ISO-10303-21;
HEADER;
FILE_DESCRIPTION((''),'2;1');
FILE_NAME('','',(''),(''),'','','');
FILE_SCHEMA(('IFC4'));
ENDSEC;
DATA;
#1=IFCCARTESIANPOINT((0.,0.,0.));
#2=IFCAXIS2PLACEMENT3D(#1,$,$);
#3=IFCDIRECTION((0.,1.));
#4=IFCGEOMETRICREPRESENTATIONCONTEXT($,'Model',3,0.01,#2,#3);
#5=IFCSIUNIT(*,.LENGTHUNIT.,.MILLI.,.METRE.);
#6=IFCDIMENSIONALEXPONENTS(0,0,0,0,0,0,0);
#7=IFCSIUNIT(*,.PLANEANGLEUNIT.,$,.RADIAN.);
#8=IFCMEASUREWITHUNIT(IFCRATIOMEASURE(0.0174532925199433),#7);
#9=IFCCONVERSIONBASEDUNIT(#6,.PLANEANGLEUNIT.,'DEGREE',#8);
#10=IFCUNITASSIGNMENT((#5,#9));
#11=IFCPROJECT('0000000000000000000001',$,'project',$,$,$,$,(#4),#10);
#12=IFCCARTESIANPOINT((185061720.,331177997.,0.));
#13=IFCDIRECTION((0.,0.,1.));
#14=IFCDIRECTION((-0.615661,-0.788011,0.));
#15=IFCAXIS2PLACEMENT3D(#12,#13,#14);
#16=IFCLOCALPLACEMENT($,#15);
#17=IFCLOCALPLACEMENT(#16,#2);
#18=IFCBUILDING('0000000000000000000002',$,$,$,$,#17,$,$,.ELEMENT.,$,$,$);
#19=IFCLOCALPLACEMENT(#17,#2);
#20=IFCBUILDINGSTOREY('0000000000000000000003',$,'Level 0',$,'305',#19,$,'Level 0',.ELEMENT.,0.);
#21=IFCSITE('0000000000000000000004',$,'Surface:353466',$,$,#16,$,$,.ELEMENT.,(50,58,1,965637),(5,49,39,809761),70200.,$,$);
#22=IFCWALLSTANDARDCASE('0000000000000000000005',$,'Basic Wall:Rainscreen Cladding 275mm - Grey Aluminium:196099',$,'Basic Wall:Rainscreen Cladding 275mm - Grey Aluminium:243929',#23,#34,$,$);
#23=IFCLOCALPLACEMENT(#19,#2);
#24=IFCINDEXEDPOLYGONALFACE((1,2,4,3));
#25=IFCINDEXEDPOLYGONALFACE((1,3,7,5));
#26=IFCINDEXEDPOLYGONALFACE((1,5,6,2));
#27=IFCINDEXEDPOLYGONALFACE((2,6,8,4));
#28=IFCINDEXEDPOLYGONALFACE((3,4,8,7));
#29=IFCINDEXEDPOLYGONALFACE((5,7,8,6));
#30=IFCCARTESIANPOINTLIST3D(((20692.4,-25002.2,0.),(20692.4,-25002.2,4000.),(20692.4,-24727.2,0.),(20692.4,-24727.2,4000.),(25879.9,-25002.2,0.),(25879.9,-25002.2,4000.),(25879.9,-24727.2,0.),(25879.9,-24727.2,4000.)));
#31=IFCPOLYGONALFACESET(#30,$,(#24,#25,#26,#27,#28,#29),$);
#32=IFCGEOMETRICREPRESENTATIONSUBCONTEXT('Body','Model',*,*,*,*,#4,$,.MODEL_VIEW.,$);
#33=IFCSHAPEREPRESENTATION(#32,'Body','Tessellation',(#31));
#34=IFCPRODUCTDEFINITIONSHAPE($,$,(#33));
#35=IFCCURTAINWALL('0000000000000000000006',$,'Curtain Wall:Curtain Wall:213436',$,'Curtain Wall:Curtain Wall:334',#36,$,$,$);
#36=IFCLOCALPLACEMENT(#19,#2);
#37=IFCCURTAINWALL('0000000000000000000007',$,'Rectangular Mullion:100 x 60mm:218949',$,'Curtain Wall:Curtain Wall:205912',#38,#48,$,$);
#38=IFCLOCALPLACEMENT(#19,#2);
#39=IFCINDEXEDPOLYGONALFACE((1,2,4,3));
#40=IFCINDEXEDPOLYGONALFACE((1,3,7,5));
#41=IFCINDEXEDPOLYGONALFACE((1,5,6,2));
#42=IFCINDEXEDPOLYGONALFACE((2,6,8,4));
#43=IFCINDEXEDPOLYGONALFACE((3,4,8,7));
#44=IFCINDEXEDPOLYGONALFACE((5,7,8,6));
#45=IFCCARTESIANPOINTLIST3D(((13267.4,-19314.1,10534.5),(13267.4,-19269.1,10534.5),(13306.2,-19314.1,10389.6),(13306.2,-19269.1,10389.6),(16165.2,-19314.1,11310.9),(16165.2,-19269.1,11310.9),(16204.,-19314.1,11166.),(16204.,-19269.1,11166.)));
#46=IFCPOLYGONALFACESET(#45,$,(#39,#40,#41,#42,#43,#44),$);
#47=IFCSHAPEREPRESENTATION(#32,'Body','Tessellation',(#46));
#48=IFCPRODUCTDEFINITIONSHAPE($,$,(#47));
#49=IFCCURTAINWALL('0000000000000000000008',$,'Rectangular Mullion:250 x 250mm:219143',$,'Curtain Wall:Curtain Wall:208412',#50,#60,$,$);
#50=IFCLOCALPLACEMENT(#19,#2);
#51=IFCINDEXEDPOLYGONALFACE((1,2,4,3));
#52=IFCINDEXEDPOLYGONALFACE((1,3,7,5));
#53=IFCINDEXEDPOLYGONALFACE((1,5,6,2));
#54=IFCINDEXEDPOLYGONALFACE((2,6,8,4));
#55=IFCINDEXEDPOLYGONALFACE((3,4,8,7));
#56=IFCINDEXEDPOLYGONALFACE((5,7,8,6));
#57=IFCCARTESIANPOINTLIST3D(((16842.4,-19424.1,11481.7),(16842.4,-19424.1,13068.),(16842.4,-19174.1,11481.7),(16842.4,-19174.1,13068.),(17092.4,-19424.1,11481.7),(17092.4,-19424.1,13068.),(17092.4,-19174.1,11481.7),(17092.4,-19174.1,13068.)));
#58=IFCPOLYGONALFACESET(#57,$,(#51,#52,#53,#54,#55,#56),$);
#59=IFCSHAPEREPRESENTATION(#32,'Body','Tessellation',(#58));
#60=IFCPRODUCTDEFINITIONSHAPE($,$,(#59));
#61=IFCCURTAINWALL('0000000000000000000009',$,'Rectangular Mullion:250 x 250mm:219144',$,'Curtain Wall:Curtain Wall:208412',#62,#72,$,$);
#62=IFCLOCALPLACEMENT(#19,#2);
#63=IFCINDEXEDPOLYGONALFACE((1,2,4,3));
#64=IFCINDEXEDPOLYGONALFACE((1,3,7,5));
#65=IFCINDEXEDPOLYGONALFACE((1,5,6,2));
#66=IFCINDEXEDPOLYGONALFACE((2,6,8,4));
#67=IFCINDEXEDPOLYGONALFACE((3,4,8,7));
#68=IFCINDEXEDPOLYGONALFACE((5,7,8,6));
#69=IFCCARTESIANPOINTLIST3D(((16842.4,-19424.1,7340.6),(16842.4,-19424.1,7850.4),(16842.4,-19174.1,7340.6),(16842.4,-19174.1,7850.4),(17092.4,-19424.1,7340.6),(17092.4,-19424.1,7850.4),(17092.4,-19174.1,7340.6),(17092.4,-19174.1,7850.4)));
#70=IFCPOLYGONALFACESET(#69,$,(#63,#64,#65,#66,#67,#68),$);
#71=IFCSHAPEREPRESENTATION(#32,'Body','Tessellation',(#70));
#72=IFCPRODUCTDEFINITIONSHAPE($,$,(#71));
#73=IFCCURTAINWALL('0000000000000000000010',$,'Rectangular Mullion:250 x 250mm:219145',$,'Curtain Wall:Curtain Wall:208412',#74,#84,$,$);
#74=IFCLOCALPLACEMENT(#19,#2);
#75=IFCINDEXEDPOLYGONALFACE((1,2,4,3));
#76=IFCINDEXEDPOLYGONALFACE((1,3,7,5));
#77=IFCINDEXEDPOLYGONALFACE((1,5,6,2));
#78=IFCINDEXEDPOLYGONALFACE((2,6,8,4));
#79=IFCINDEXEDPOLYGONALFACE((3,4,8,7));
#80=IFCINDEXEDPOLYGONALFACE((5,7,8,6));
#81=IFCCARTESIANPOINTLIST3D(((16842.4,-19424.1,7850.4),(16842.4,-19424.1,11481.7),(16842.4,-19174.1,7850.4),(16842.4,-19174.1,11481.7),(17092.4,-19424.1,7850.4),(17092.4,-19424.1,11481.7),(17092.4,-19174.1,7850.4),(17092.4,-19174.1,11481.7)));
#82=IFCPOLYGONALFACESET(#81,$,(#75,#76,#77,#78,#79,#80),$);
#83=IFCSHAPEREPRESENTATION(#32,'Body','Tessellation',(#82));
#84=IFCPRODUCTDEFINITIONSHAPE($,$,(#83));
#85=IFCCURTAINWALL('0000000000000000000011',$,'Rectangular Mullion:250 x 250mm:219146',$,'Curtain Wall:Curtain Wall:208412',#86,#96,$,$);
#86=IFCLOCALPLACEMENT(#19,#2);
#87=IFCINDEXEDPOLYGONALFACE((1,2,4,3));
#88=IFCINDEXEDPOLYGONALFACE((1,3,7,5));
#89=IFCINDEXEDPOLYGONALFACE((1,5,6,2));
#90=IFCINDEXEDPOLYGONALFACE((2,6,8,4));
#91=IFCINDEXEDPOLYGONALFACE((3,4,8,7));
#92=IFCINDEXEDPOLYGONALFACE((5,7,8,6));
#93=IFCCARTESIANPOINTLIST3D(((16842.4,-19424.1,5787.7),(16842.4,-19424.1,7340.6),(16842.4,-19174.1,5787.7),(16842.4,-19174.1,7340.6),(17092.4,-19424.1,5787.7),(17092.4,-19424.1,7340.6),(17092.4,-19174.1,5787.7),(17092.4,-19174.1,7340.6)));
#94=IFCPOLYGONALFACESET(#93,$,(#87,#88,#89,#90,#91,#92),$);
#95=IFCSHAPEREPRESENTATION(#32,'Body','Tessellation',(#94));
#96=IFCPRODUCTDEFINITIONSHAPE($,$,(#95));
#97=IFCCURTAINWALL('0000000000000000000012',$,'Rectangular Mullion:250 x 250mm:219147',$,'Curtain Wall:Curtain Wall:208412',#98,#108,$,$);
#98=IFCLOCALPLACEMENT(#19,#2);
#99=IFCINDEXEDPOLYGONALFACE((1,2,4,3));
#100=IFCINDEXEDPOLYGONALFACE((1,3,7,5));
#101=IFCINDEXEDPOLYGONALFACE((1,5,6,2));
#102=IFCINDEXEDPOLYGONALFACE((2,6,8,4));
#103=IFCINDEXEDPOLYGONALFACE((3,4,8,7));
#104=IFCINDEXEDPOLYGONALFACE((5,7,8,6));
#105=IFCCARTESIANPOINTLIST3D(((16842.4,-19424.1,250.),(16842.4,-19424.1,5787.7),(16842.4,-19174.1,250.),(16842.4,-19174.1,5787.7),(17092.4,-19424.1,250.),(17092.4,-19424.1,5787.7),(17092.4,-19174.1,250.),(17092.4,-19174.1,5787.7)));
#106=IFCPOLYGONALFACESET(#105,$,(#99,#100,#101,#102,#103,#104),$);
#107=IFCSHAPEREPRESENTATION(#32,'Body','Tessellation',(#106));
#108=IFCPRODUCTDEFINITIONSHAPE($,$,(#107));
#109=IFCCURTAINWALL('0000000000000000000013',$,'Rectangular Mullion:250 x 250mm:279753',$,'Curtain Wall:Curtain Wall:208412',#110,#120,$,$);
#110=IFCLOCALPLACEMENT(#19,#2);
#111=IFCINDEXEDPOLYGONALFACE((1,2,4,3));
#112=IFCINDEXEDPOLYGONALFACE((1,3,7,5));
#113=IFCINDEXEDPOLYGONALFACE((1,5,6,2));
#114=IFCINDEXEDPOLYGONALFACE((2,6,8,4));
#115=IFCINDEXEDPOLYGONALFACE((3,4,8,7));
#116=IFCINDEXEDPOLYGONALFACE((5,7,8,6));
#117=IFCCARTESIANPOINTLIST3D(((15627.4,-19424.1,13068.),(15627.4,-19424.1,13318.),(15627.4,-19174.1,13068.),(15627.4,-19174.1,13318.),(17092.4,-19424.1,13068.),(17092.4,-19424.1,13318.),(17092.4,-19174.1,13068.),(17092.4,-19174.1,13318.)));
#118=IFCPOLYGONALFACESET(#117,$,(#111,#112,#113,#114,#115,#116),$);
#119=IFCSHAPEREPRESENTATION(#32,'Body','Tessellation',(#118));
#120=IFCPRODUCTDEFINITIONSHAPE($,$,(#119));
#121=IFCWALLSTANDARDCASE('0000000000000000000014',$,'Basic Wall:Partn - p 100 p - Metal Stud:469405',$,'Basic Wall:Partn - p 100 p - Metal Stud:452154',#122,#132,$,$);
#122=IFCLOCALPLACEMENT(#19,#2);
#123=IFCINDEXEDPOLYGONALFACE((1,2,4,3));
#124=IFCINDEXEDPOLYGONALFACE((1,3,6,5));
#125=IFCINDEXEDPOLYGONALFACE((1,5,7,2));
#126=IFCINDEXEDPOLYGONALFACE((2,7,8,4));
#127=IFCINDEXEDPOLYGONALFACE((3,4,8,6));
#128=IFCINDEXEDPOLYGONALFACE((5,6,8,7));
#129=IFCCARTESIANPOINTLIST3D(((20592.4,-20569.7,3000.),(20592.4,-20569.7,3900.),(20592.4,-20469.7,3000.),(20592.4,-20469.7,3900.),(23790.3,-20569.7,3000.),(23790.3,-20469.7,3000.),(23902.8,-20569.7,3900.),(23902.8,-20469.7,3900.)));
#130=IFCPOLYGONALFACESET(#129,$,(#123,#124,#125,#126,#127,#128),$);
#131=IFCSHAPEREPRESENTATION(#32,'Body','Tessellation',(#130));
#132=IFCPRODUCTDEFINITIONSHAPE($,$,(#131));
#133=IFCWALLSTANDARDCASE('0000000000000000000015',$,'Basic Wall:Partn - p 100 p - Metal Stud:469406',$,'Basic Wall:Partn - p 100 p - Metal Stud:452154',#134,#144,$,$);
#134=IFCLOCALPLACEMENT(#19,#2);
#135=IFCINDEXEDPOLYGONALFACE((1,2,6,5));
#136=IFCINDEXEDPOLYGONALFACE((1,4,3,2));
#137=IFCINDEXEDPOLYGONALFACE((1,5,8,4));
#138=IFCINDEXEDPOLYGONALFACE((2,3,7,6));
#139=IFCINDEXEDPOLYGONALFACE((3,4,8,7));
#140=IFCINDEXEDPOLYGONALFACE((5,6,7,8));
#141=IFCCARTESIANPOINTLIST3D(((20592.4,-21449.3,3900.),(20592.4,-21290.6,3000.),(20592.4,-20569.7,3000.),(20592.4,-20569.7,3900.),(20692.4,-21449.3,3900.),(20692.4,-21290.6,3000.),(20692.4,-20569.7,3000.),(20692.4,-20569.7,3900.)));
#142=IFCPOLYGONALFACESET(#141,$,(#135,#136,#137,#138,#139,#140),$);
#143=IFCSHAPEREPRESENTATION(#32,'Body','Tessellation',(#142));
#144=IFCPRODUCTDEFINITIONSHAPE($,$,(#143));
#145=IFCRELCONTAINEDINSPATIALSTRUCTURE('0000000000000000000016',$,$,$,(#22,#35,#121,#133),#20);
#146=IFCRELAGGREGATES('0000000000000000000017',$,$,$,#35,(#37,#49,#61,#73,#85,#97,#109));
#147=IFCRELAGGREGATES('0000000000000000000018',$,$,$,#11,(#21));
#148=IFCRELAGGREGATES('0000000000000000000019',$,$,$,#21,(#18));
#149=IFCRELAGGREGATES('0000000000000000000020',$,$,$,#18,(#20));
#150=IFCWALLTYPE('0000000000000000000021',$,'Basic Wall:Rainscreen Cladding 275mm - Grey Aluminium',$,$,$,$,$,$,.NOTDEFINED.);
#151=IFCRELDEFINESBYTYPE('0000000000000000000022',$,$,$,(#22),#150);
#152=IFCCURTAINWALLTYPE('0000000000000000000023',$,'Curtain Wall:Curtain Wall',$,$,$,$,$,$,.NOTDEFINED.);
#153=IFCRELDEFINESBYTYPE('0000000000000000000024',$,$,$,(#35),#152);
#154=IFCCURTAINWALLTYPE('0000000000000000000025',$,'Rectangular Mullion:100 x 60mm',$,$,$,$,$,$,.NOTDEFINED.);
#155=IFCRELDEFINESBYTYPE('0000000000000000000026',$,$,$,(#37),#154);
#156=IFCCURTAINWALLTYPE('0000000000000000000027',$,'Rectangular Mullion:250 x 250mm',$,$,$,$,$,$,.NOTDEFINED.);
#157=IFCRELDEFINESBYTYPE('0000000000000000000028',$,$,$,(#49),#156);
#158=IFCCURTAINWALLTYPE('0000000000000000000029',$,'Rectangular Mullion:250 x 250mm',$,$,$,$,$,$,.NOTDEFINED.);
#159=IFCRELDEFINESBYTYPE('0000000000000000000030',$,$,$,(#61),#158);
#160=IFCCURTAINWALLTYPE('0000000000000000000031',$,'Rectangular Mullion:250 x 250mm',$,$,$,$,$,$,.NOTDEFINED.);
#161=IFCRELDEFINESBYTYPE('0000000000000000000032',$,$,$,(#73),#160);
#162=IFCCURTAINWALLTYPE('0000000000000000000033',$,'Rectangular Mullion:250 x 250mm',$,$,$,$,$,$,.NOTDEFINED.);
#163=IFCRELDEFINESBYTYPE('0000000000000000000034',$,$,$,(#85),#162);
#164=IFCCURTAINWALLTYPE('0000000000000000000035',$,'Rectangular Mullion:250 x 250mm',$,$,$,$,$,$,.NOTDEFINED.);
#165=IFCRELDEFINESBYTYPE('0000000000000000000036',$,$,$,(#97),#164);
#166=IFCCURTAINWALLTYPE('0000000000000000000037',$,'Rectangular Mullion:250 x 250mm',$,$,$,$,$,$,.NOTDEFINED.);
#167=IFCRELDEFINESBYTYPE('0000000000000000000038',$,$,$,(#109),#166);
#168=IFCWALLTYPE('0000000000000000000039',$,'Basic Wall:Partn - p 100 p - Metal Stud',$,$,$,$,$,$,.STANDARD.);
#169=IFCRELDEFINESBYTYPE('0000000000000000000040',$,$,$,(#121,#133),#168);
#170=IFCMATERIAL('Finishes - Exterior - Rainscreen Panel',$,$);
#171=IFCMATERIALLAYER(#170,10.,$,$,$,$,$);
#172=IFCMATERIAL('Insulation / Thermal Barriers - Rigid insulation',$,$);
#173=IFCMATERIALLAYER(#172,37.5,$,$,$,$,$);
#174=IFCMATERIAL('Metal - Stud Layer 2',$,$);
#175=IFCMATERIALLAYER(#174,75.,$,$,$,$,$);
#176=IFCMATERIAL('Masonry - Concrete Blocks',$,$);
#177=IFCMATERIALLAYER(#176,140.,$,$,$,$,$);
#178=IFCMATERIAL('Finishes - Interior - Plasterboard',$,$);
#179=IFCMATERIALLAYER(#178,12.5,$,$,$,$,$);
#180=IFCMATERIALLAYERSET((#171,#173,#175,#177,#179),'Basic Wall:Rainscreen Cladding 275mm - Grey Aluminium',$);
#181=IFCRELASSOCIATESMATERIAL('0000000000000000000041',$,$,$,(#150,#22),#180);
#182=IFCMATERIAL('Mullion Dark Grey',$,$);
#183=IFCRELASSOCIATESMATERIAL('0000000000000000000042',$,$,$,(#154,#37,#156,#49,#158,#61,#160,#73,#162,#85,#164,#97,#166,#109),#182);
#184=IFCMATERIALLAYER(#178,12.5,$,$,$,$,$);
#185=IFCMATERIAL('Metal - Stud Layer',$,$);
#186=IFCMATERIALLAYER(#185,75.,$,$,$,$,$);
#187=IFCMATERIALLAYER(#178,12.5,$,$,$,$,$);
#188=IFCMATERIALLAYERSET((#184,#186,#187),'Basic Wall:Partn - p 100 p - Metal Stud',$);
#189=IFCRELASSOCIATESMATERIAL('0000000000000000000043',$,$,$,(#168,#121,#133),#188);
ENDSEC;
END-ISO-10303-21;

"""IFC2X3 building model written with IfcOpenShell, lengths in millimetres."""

from ifc_helpers import new_model, entity, si_unit, converted_unit, direction, frame, frame_2d, origin, origin_2d_with_axis, place, context, subcontext, project, spatial, rectangle, extrude, clip, halfspace, source, transform, mapped, material, layer, layer_set, layer_usage, type_object, type_shapes, element, aggregate, save


model = new_model("IFC2X3")

# Units and contexts
model_context = context("Model", 3, precision=0.01, world=origin(), true_north=direction((0.0, 1.0)))
body_context = subcontext(model_context, "Body", "Model", "MODEL_VIEW")
ifc_project = project(units=[si_unit("LENGTHUNIT", "METRE", prefix="MILLI"), converted_unit("PLANEANGLEUNIT", "DEGREE", entity("IfcRatioMeasure", 0.0174532925199433), si_unit("PLANEANGLEUNIT", "RADIAN"), dimensions=[0, 0, 0, 0, 0, 0, 0])], contexts=[model_context])

# Site, building, storey
site_placement = place(None, frame((185061720.0, 331177997.0, 0.0), z_axis=(0.0, 0.0, 1.0), x_axis=(-0.615661, -0.788011, 0.0)))
site = spatial("IfcSite", under=ifc_project, at=site_placement, Name="Surface:353466", CompositionType="ELEMENT", RefLatitude=(50, 58, 1, 965637), RefLongitude=(5, 49, 39, 809761), RefElevation=70200.0)
building_placement = place(site_placement, origin())
building = spatial("IfcBuilding", under=site, at=building_placement, CompositionType="ELEMENT")
storey_placement = place(building_placement, origin())
storey = spatial("IfcBuildingStorey", under=building, at=storey_placement, Name="Level 0", ObjectType="305", LongName="Level 0", CompositionType="ELEMENT", Elevation=0.0)

# Wall
ifc_material_1 = material(Name="Finishes - Exterior - Rainscreen Panel")
ifc_layer_1 = layer(ifc_material_1, 10.0)
ifc_material_2 = material(Name="Insulation / Thermal Barriers - Rigid insulation")
ifc_layer_2 = layer(ifc_material_2, 37.5)
ifc_material_3 = material(Name="Metal - Stud Layer 2")
ifc_layer_3 = layer(ifc_material_3, 75.0)
ifc_material_4 = material(Name="Masonry - Concrete Blocks")
ifc_layer_4 = layer(ifc_material_4, 140.0)
ifc_material_5 = material(Name="Finishes - Interior - Plasterboard")
ifc_layer_5 = layer(ifc_material_5, 12.5)
ifc_layer_set_1 = layer_set([ifc_layer_1, ifc_layer_2, ifc_layer_3, ifc_layer_4, ifc_layer_5], Name="Basic Wall:Rainscreen Cladding 275mm - Grey Aluminium")
ifc_layer_usage_1 = layer_usage(ifc_layer_set_1, "AXIS2", "POSITIVE", -137.5)
wall_type_1 = type_object("IfcWallType", Name="Basic Wall:Rainscreen Cladding 275mm - Grey Aluminium", PredefinedType="NOTDEFINED", material=ifc_layer_set_1)
wall_1_placement = place(storey_placement, frame((20692.4, -24864.7, 0.0)))
element("IfcWallStandardCase", 1, at=wall_1_placement, inside=storey, type_object=wall_type_1, material=ifc_layer_usage_1, Name="Basic Wall:Rainscreen Cladding 275mm - Grey Aluminium:196099", ObjectType="Basic Wall:Rainscreen Cladding 275mm - Grey Aluminium:243929", context=body_context, shape_type="Clipping", body=[
    clip(extrude(rectangle(XDim=5187.5, YDim=275.0, at=frame_2d((2593.8, 0.0), x_axis=(-1.0, 0.0))), origin(), (0.0, 0.0, 1.0), 4000.0), halfspace(frame((0.0, 0.0, -738.5)), True)),
])

# Curtain walls
curtain_wall_type_1 = type_object("IfcCurtainWallType", Name="Curtain Wall:Curtain Wall", PredefinedType="NOTDEFINED")
curtain_wall_1_placement = place(storey_placement, origin())
curtain_wall_1 = element("IfcCurtainWall", 2, at=curtain_wall_1_placement, inside=storey, type_object=curtain_wall_type_1, Name="Curtain Wall:Curtain Wall:213436", ObjectType="Curtain Wall:Curtain Wall:334")
ifc_material_6 = material(Name="Mullion Dark Grey")
curtain_wall_type_2 = type_object("IfcCurtainWallType", Name="Rectangular Mullion:100 x 60mm", PredefinedType="NOTDEFINED", material=ifc_material_6)
shared_shape_1 = source(origin(), body_context, "Body", "SweptSolid", [
    extrude(rectangle(XDim=150.0, YDim=45.0, at=frame_2d((0.0, 0.0), x_axis=(1.0, 0.0))), frame((0.0, -7.5, -3000.0)), (0.0, 0.0, 1.0), 3000.0),
])
type_shapes(curtain_wall_type_2, [shared_shape_1])
curtain_wall_2_placement = place(storey_placement, frame((16184.6, -19299.1, 11238.5), z_axis=(0.965926, 0.0, 0.258819), x_axis=(-0.258819, 0.0, 0.965926)))
curtain_wall_2 = element("IfcCurtainWall", 3, at=curtain_wall_2_placement, type_object=curtain_wall_type_2, material=ifc_material_6, Name="Rectangular Mullion:100 x 60mm:218949", ObjectType="Curtain Wall:Curtain Wall:205912", context=body_context, shape_type="MappedRepresentation", body=[
    mapped(shared_shape_1, transform((0.0, 0.0, 0.0), scale=1.0)),
])
curtain_wall_type_3 = type_object("IfcCurtainWallType", Name="Rectangular Mullion:250 x 250mm", PredefinedType="NOTDEFINED", material=ifc_material_6)
shared_shape_2 = source(origin(), body_context, "Body", "SweptSolid", [
    extrude(rectangle(XDim=250.0, YDim=250.0, at=origin_2d_with_axis()), frame((-125.0, 0.0, -1586.2), z_axis=(0.0, 0.0, 1.0), x_axis=(-1.0, 0.0, 0.0)), (0.0, 0.0, 1.0), 1586.2),
])
type_shapes(curtain_wall_type_3, [shared_shape_2])
curtain_wall_3_placement = place(storey_placement, frame((17092.4, -19299.1, 11481.7), z_axis=(0.0, 0.0, -1.0), x_axis=(1.0, 0.0, 0.0)))
curtain_wall_3 = element("IfcCurtainWall", 4, at=curtain_wall_3_placement, type_object=curtain_wall_type_3, material=ifc_material_6, Name="Rectangular Mullion:250 x 250mm:219143", ObjectType="Curtain Wall:Curtain Wall:208412", context=body_context, shape_type="MappedRepresentation", body=[
    mapped(shared_shape_2, transform((0.0, 0.0, 0.0), scale=1.0)),
])
curtain_wall_type_4 = type_object("IfcCurtainWallType", Name="Rectangular Mullion:250 x 250mm", PredefinedType="NOTDEFINED", material=ifc_material_6)
shared_shape_3 = source(origin(), body_context, "Body", "SweptSolid", [
    extrude(rectangle(XDim=250.0, YDim=250.0, at=origin_2d_with_axis()), frame((-125.0, 0.0, -509.8), z_axis=(0.0, 0.0, 1.0), x_axis=(-1.0, 0.0, 0.0)), (0.0, 0.0, 1.0), 509.8),
])
type_shapes(curtain_wall_type_4, [shared_shape_3])
curtain_wall_4_placement = place(storey_placement, frame((17092.4, -19299.1, 7340.6), z_axis=(0.0, 0.0, -1.0), x_axis=(1.0, 0.0, 0.0)))
curtain_wall_4 = element("IfcCurtainWall", 5, at=curtain_wall_4_placement, type_object=curtain_wall_type_4, material=ifc_material_6, Name="Rectangular Mullion:250 x 250mm:219144", ObjectType="Curtain Wall:Curtain Wall:208412", context=body_context, shape_type="MappedRepresentation", body=[
    mapped(shared_shape_3, transform((0.0, 0.0, 0.0), scale=1.0)),
])
curtain_wall_type_5 = type_object("IfcCurtainWallType", Name="Rectangular Mullion:250 x 250mm", PredefinedType="NOTDEFINED", material=ifc_material_6)
shared_shape_4 = source(origin(), body_context, "Body", "SweptSolid", [
    extrude(rectangle(XDim=250.0, YDim=250.0, at=origin_2d_with_axis()), frame((-125.0, 0.0, -3631.3), z_axis=(0.0, 0.0, 1.0), x_axis=(-1.0, 0.0, 0.0)), (0.0, 0.0, 1.0), 3631.3),
])
type_shapes(curtain_wall_type_5, [shared_shape_4])
curtain_wall_5_placement = place(storey_placement, frame((17092.4, -19299.1, 7850.4), z_axis=(0.0, 0.0, -1.0), x_axis=(1.0, 0.0, 0.0)))
curtain_wall_5 = element("IfcCurtainWall", 6, at=curtain_wall_5_placement, type_object=curtain_wall_type_5, material=ifc_material_6, Name="Rectangular Mullion:250 x 250mm:219145", ObjectType="Curtain Wall:Curtain Wall:208412", context=body_context, shape_type="MappedRepresentation", body=[
    mapped(shared_shape_4, transform((0.0, 0.0, 0.0), scale=1.0)),
])
curtain_wall_type_6 = type_object("IfcCurtainWallType", Name="Rectangular Mullion:250 x 250mm", PredefinedType="NOTDEFINED", material=ifc_material_6)
shared_shape_5 = source(origin(), body_context, "Body", "SweptSolid", [
    extrude(rectangle(XDim=250.0, YDim=250.0, at=origin_2d_with_axis()), frame((-125.0, 0.0, -1552.9), z_axis=(0.0, 0.0, 1.0), x_axis=(-1.0, 0.0, 0.0)), (0.0, 0.0, 1.0), 1552.9),
])
type_shapes(curtain_wall_type_6, [shared_shape_5])
curtain_wall_6_placement = place(storey_placement, frame((17092.4, -19299.1, 5787.7), z_axis=(0.0, 0.0, -1.0), x_axis=(1.0, 0.0, 0.0)))
curtain_wall_6 = element("IfcCurtainWall", 7, at=curtain_wall_6_placement, type_object=curtain_wall_type_6, material=ifc_material_6, Name="Rectangular Mullion:250 x 250mm:219146", ObjectType="Curtain Wall:Curtain Wall:208412", context=body_context, shape_type="MappedRepresentation", body=[
    mapped(shared_shape_5, transform((0.0, 0.0, 0.0), scale=1.0)),
])
curtain_wall_type_7 = type_object("IfcCurtainWallType", Name="Rectangular Mullion:250 x 250mm", PredefinedType="NOTDEFINED", material=ifc_material_6)
shared_shape_6 = source(origin(), body_context, "Body", "SweptSolid", [
    extrude(rectangle(XDim=250.0, YDim=250.0, at=origin_2d_with_axis()), frame((-125.0, 0.0, -5537.7), z_axis=(0.0, 0.0, 1.0), x_axis=(-1.0, 0.0, 0.0)), (0.0, 0.0, 1.0), 5537.7),
])
type_shapes(curtain_wall_type_7, [shared_shape_6])
curtain_wall_7_placement = place(storey_placement, frame((17092.4, -19299.1, 250.0), z_axis=(0.0, 0.0, -1.0), x_axis=(1.0, 0.0, 0.0)))
curtain_wall_7 = element("IfcCurtainWall", 8, at=curtain_wall_7_placement, type_object=curtain_wall_type_7, material=ifc_material_6, Name="Rectangular Mullion:250 x 250mm:219147", ObjectType="Curtain Wall:Curtain Wall:208412", context=body_context, shape_type="MappedRepresentation", body=[
    mapped(shared_shape_6, transform((0.0, 0.0, 0.0), scale=1.0)),
])
curtain_wall_type_8 = type_object("IfcCurtainWallType", Name="Rectangular Mullion:250 x 250mm", PredefinedType="NOTDEFINED", material=ifc_material_6)
shared_shape_7 = source(origin(), body_context, "Body", "SweptSolid", [
    extrude(rectangle(XDim=250.0, YDim=250.0, at=origin_2d_with_axis()), frame((-125.0, 0.0, -1465.0), z_axis=(0.0, 0.0, 1.0), x_axis=(-1.0, 0.0, 0.0)), (0.0, 0.0, 1.0), 1465.0),
])
type_shapes(curtain_wall_type_8, [shared_shape_7])
curtain_wall_8_placement = place(storey_placement, frame((17092.4, -19299.1, 13318.0), z_axis=(1.0, 0.0, 0.0), x_axis=(0.0, 0.0, 1.0)))
curtain_wall_8 = element("IfcCurtainWall", 9, at=curtain_wall_8_placement, type_object=curtain_wall_type_8, material=ifc_material_6, Name="Rectangular Mullion:250 x 250mm:279753", ObjectType="Curtain Wall:Curtain Wall:208412", context=body_context, shape_type="MappedRepresentation", body=[
    mapped(shared_shape_7, transform((0.0, 0.0, 0.0), scale=1.0)),
])
aggregate(curtain_wall_1, [curtain_wall_2, curtain_wall_3, curtain_wall_4, curtain_wall_5, curtain_wall_6, curtain_wall_7, curtain_wall_8])

# Walls
ifc_layer_6 = layer(ifc_material_5, 12.5)
ifc_material_7 = material(Name="Metal - Stud Layer")
ifc_layer_7 = layer(ifc_material_7, 75.0)
ifc_layer_8 = layer(ifc_material_5, 12.5)
ifc_layer_set_2 = layer_set([ifc_layer_6, ifc_layer_7, ifc_layer_8], Name="Basic Wall:Partn - p 100 p - Metal Stud")
ifc_layer_usage_2 = layer_usage(ifc_layer_set_2, "AXIS2", "POSITIVE", -50.0)
wall_type_2 = type_object("IfcWallType", Name="Basic Wall:Partn - p 100 p - Metal Stud", PredefinedType="STANDARD", material=ifc_layer_set_2)
wall_2_placement = place(storey_placement, frame((23902.8, -20519.7, 3000.0), z_axis=(0.0, 0.0, 1.0), x_axis=(-1.0, 0.0, 0.0)))
element("IfcWallStandardCase", 10, at=wall_2_placement, inside=storey, type_object=wall_type_2, material=ifc_layer_usage_2, Name="Basic Wall:Partn - p 100 p - Metal Stud:469405", ObjectType="Basic Wall:Partn - p 100 p - Metal Stud:452154", context=body_context, shape_type="Clipping", body=[
    clip(extrude(rectangle(XDim=3310.4, YDim=100.0, at=frame_2d((1655.2, 0.0), x_axis=(-1.0, 0.0))), origin(), (0.0, 0.0, 1.0), 900.0), halfspace(frame((112.5, -50.0, 0.0), z_axis=(-0.992278, 0.0, -0.124035), x_axis=(0.0, 1.0, 0.0)), False)),
])
ifc_layer_usage_3 = layer_usage(ifc_layer_set_2, "AXIS2", "POSITIVE", -50.0)
wall_3_placement = place(storey_placement, frame((20642.4, -20569.7, 3000.0), z_axis=(0.0, 0.0, 1.0), x_axis=(0.0, -1.0, 0.0)))
element("IfcWallStandardCase", 11, at=wall_3_placement, inside=storey, type_object=wall_type_2, material=ifc_layer_usage_3, Name="Basic Wall:Partn - p 100 p - Metal Stud:469406", ObjectType="Basic Wall:Partn - p 100 p - Metal Stud:452154", context=body_context, shape_type="Clipping", body=[
    clip(extrude(rectangle(XDim=879.6, YDim=100.0, at=frame_2d((439.8, 0.0), x_axis=(-1.0, 0.0))), origin(), (0.0, 0.0, 1.0), 900.0), halfspace(frame((879.6, -50.0, 900.0), z_axis=(0.984808, 0.0, -0.173648), x_axis=(0.0, 1.0, 0.0)), False)),
])

save(model, "model.ifc")
